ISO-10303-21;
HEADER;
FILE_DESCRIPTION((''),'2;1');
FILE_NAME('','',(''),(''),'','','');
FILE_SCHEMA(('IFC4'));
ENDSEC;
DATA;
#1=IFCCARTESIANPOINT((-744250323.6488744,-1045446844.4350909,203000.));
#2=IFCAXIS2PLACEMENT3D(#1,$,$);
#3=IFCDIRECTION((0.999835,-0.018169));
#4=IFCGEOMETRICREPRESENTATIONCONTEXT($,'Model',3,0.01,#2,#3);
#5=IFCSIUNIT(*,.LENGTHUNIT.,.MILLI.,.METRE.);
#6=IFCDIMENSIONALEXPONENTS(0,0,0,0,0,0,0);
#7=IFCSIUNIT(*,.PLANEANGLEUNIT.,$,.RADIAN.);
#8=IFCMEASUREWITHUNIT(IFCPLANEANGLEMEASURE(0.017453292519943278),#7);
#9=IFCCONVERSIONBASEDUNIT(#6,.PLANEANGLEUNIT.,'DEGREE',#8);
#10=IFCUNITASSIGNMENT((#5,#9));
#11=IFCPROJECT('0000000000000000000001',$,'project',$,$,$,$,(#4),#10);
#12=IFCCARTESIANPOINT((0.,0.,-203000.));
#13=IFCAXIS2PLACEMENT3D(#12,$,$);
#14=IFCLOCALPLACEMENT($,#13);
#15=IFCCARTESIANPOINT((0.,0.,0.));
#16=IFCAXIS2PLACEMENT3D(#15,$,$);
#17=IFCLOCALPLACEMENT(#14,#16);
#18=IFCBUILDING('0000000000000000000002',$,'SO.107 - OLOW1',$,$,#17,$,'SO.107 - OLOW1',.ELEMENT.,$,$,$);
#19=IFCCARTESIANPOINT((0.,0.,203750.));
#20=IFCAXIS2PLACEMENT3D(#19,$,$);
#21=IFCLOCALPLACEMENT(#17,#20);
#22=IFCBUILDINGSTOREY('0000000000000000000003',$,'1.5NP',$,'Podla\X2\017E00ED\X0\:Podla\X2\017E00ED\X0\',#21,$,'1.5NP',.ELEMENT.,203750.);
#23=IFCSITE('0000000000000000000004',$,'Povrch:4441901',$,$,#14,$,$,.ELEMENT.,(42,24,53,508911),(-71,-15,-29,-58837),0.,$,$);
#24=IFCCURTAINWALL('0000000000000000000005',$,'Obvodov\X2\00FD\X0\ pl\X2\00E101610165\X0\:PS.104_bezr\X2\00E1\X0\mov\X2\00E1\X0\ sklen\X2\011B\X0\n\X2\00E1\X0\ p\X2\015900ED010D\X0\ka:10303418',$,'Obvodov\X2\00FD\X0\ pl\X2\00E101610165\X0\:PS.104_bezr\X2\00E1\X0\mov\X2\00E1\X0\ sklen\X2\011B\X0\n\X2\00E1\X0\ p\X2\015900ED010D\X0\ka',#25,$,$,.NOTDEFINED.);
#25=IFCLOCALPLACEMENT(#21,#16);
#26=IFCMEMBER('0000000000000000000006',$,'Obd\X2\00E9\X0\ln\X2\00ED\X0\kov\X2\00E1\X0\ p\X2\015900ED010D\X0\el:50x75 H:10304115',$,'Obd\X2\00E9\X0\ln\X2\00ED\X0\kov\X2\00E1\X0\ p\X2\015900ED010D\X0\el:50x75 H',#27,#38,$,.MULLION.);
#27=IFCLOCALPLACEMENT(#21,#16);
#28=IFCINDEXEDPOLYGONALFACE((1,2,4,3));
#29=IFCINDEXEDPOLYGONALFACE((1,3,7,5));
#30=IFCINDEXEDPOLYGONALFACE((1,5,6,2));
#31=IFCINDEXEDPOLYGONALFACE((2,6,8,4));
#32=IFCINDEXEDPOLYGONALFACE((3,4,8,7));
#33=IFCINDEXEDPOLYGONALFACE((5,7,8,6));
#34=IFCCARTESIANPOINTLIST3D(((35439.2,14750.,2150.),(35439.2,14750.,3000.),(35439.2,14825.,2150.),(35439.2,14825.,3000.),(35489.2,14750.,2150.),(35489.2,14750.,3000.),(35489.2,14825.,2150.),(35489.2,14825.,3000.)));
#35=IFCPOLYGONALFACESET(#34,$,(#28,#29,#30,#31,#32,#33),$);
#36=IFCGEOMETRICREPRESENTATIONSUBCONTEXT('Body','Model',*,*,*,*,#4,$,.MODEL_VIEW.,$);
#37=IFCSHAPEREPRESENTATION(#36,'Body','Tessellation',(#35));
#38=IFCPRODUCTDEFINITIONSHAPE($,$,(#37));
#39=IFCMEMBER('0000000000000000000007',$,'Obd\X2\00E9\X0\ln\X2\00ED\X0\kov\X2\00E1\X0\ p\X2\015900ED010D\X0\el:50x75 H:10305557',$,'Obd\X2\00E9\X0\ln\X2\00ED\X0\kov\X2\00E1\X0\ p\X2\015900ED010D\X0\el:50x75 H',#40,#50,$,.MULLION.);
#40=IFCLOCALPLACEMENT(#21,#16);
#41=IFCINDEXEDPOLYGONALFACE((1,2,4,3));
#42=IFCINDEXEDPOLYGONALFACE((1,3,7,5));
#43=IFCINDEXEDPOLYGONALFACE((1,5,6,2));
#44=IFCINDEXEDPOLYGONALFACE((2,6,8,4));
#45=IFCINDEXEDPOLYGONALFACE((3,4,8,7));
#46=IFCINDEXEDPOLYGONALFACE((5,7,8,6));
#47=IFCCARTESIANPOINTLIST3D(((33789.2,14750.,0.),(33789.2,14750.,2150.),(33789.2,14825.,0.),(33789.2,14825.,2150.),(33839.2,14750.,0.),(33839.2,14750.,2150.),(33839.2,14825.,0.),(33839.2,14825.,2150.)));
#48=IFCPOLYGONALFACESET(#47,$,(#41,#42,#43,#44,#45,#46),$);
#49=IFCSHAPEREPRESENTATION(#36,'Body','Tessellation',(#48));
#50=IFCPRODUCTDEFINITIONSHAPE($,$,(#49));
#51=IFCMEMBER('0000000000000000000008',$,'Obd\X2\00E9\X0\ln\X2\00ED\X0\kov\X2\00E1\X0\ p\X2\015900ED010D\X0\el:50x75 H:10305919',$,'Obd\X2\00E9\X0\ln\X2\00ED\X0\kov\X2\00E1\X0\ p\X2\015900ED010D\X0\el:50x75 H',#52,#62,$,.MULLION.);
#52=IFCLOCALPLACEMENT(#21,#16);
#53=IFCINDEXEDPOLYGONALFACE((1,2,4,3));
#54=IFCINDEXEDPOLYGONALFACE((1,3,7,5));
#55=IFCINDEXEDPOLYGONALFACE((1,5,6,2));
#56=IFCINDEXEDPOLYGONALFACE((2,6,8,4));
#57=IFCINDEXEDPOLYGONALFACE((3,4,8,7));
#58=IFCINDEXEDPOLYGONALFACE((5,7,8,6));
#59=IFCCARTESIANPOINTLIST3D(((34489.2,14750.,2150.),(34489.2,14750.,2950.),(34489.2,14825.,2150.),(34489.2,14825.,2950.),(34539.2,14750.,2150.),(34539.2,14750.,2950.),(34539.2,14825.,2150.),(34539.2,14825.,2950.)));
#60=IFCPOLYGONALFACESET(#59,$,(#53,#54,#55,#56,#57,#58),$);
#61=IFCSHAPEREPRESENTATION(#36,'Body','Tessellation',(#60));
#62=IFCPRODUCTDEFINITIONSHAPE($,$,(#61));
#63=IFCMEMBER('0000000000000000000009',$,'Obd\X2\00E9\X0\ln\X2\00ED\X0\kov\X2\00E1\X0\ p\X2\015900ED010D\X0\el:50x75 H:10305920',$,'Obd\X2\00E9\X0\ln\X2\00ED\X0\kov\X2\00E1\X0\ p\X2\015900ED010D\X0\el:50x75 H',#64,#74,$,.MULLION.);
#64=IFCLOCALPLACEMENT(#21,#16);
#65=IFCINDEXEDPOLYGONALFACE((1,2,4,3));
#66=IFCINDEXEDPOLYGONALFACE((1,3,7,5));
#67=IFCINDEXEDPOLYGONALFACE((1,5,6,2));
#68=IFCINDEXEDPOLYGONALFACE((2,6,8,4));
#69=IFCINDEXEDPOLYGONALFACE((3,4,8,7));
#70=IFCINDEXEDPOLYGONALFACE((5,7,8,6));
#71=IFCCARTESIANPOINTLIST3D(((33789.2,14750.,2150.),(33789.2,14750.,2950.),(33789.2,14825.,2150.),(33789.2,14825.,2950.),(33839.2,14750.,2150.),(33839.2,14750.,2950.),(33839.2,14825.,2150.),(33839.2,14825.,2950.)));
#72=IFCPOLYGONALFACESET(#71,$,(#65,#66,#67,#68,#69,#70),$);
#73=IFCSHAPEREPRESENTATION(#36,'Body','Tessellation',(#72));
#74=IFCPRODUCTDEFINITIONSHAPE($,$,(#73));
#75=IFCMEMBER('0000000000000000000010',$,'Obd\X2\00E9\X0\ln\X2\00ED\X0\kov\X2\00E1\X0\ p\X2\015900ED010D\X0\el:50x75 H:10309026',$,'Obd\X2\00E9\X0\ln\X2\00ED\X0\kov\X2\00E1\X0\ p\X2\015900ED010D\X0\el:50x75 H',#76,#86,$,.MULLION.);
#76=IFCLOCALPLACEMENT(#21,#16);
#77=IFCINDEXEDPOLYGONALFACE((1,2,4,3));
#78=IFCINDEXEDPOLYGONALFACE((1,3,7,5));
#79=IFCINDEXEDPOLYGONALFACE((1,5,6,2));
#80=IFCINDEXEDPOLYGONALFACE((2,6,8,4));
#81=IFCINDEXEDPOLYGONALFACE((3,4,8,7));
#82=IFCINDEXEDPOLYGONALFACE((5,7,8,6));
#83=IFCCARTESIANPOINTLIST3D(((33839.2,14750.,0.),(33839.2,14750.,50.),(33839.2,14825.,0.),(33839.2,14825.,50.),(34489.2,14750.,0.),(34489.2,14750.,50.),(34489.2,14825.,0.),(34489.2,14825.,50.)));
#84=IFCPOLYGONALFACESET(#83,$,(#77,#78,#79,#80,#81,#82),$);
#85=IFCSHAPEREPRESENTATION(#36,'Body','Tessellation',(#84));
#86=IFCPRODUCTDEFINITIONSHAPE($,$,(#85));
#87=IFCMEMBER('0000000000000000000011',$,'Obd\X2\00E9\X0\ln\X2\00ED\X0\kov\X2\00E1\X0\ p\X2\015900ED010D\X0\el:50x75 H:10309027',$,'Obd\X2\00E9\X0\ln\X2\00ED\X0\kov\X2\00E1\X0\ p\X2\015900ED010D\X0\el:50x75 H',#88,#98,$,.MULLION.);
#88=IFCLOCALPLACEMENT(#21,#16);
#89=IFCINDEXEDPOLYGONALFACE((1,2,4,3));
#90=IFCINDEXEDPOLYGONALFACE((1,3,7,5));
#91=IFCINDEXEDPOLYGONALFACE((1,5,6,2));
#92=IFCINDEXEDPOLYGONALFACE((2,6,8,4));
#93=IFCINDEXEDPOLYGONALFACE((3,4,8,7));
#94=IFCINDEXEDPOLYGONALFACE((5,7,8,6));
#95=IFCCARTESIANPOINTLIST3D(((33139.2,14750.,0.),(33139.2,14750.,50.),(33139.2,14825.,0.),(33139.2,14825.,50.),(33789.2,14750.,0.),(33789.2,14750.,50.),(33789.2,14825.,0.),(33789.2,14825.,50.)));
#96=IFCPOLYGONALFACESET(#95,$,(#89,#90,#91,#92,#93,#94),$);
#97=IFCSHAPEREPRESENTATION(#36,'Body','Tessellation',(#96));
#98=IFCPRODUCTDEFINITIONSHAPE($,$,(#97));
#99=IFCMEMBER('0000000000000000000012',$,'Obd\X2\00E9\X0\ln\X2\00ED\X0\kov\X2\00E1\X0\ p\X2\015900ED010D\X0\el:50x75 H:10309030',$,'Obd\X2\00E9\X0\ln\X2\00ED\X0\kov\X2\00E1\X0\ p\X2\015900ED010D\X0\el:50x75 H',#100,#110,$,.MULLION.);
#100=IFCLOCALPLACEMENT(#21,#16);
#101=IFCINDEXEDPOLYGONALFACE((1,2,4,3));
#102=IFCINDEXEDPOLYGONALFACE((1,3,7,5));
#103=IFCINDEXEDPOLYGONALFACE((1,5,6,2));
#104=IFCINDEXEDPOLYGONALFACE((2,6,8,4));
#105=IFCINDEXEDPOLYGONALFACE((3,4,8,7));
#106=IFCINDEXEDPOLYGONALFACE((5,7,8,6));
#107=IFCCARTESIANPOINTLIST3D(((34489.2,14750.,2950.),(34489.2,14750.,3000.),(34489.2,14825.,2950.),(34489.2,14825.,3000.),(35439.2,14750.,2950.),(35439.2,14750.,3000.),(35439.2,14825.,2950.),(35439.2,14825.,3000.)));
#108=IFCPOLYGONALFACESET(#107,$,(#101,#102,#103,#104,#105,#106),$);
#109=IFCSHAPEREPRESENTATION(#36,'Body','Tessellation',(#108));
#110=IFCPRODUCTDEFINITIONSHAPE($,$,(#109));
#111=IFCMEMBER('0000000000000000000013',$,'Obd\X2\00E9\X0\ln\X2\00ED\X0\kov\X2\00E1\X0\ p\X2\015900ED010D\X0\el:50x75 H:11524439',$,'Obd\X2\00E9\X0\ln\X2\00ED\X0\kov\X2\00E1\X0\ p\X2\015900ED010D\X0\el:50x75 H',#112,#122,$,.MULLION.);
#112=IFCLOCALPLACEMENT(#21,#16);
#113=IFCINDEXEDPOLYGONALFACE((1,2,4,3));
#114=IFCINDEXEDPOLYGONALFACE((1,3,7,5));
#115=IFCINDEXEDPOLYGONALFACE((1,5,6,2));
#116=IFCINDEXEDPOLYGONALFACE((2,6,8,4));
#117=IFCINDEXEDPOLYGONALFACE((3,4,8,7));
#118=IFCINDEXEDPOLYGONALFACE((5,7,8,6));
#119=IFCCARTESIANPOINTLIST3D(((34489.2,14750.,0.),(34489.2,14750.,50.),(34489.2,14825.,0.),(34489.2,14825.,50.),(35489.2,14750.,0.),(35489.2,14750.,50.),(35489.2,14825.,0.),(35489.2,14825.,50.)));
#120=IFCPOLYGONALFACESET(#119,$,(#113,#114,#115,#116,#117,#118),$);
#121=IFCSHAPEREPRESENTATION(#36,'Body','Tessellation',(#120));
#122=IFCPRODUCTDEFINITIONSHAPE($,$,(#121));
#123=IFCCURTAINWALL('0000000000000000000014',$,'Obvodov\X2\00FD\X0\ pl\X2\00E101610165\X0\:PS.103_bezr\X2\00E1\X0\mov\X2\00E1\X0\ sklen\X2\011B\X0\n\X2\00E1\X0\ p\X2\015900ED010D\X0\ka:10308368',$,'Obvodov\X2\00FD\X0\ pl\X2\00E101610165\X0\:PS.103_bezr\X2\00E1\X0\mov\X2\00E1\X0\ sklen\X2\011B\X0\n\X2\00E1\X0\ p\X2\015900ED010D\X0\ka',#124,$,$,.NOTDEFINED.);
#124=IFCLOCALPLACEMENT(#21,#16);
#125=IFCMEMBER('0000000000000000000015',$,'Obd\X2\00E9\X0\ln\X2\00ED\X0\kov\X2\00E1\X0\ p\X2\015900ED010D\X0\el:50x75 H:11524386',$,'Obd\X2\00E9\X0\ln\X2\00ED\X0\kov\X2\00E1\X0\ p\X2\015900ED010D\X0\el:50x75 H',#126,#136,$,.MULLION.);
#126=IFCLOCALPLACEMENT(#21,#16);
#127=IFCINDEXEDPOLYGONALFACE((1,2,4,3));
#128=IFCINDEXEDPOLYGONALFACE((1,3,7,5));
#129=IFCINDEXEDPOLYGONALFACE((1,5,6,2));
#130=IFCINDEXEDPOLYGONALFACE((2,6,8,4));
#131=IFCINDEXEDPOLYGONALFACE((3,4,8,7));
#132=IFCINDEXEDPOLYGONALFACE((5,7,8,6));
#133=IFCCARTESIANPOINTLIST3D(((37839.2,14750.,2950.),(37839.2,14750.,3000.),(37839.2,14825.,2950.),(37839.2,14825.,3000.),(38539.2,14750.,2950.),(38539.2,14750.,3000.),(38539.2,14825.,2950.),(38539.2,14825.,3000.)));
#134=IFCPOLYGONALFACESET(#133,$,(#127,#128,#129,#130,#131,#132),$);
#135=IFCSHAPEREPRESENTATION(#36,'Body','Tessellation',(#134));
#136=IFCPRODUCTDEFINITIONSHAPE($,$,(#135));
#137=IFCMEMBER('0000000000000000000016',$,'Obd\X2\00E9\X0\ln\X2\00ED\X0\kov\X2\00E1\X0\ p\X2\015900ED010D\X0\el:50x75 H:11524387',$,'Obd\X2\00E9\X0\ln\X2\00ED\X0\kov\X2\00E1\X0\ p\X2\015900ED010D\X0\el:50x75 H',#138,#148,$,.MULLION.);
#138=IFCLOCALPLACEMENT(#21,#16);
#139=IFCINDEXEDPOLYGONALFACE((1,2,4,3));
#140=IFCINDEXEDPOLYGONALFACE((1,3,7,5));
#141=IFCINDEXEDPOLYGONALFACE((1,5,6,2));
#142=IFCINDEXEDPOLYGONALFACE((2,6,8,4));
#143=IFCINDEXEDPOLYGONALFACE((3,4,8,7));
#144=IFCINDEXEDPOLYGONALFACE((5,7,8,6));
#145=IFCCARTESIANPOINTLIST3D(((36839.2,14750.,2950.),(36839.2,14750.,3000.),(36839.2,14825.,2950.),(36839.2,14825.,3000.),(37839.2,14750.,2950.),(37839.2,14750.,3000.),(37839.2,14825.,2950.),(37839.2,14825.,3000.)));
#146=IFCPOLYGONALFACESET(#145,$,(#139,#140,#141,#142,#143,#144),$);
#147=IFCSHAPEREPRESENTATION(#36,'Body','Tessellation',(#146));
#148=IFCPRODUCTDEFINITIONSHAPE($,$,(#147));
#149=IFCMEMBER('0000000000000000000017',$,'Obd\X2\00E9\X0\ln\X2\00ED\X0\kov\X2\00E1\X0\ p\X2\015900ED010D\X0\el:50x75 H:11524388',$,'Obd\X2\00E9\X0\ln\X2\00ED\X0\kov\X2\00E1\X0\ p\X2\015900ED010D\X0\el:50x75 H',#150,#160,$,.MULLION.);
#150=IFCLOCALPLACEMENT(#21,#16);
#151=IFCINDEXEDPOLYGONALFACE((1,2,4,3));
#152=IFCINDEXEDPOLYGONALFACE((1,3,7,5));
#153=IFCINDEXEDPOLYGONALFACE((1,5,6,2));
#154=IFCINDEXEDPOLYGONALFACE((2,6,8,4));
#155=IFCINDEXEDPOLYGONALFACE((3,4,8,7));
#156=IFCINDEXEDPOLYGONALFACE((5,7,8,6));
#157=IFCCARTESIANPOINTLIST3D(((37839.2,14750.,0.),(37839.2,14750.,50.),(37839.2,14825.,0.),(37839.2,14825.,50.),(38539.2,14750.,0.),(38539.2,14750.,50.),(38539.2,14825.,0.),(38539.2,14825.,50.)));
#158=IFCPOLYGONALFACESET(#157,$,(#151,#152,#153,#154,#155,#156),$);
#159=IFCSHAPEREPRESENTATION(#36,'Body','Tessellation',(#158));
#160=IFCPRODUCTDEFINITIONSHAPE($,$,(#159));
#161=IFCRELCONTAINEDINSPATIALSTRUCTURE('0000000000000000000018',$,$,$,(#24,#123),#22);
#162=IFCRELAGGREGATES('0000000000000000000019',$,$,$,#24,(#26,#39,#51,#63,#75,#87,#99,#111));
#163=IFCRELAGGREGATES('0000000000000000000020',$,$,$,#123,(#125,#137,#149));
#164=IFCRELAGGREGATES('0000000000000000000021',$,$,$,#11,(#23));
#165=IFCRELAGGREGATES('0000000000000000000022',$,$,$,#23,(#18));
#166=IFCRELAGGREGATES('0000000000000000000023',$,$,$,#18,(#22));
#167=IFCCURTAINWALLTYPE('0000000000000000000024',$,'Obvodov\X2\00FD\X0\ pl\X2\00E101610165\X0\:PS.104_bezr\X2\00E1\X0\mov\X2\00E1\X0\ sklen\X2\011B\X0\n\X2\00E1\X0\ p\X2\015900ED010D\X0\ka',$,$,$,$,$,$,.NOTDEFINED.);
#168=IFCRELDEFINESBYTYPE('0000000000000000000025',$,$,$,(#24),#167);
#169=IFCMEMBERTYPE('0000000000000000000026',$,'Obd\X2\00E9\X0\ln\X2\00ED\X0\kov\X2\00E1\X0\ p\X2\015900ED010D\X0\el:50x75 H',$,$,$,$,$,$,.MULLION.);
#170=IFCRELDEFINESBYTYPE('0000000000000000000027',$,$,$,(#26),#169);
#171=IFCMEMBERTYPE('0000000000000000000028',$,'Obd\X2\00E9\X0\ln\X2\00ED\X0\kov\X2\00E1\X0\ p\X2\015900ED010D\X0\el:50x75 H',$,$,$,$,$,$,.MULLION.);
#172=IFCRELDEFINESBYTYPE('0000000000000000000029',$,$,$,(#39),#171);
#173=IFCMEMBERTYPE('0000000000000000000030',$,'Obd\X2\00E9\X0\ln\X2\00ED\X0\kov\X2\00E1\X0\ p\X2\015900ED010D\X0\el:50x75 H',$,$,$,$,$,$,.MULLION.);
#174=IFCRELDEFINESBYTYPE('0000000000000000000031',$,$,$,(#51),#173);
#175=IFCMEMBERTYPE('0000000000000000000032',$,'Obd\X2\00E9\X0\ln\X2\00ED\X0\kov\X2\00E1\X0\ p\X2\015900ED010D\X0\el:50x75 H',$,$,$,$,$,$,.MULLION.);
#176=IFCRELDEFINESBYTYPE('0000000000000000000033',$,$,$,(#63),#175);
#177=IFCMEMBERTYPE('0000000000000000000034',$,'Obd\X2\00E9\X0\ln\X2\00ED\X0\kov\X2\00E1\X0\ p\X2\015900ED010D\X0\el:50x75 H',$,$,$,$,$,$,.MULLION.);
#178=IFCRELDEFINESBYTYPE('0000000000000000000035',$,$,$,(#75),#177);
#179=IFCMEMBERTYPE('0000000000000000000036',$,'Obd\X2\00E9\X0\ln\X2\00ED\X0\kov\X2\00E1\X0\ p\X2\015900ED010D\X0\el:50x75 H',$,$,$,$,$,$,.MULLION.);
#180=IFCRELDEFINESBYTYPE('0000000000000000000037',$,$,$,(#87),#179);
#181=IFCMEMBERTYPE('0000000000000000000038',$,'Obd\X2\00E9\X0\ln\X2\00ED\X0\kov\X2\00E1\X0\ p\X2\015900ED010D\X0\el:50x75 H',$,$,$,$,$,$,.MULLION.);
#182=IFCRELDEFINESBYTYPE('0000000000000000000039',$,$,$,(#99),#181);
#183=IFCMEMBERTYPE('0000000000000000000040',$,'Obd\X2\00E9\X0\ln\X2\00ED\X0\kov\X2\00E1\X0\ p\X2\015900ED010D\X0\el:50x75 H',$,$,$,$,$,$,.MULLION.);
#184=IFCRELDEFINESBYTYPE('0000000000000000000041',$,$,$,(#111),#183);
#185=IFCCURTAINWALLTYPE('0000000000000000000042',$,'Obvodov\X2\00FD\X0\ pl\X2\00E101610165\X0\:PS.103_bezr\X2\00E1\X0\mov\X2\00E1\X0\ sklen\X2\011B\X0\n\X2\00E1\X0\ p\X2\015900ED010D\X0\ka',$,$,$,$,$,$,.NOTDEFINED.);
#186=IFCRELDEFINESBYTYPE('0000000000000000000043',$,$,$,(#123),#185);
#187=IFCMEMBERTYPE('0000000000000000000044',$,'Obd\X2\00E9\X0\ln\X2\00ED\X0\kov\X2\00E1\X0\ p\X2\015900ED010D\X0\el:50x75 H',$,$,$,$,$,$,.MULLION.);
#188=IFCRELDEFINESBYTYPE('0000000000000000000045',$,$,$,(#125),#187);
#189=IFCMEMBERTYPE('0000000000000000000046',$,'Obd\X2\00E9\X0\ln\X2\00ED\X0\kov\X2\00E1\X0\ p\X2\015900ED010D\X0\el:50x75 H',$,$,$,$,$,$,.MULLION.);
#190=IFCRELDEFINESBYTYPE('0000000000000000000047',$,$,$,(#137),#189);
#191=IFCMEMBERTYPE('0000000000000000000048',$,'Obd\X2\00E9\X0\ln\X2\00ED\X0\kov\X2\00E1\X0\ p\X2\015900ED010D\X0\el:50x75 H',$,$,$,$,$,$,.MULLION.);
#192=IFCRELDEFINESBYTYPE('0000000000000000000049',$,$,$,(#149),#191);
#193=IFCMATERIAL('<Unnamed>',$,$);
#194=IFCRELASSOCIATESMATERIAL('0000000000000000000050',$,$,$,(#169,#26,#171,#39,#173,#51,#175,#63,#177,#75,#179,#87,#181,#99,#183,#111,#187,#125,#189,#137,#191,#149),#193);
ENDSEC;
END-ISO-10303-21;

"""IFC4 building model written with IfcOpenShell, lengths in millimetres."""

from ifc_helpers import new_model, entity, si_unit, converted_unit, direction, frame, origin, place, context, subcontext, project, spatial, indexed_curve, outline, extrude, source, transform, mapped, material, type_object, type_shapes, element, aggregate, save


model = new_model("IFC4")

# Units and contexts
model_context = context("Model", 3, precision=0.01, world=frame((-744250323.6488744, -1045446844.4350909, 203000.0)), true_north=direction((0.999835, -0.018169)))
body_context = subcontext(model_context, "Body", "Model", "MODEL_VIEW")
ifc_project = project(units=[si_unit("LENGTHUNIT", "METRE", prefix="MILLI"), converted_unit("PLANEANGLEUNIT", "DEGREE", entity("IfcPlaneAngleMeasure", 0.017453292519943278), si_unit("PLANEANGLEUNIT", "RADIAN"), dimensions=[0, 0, 0, 0, 0, 0, 0])], contexts=[model_context])

# Site, building, storey
site_placement = place(None, frame((0.0, 0.0, -203000.0)))
site = spatial("IfcSite", under=ifc_project, at=site_placement, Name="Povrch:4441901", CompositionType="ELEMENT", RefLatitude=(42, 24, 53, 508911), RefLongitude=(-71, -15, -29, -58837), RefElevation=0.0)
building_placement = place(site_placement, origin())
building = spatial("IfcBuilding", under=site, at=building_placement, Name="SO.107 - OLOW1", LongName="SO.107 - OLOW1", CompositionType="ELEMENT")
storey_placement = place(building_placement, frame((0.0, 0.0, 203750.0)))
storey = spatial("IfcBuildingStorey", under=building, at=storey_placement, Name="1.5NP", ObjectType="Podlaží:Podlaží", LongName="1.5NP", CompositionType="ELEMENT", Elevation=203750.0)

# Curtain walls, members
curtain_wall_type_1 = type_object("IfcCurtainWallType", Name="Obvodový plášť:PS.104_bezrámová skleněná příčka", PredefinedType="NOTDEFINED")
curtain_wall_1_placement = place(storey_placement, frame((0.0, 0.0, -203750.0)))
curtain_wall_1 = element("IfcCurtainWall", 1, at=curtain_wall_1_placement, inside=storey, type_object=curtain_wall_type_1, Name="Obvodový plášť:PS.104_bezrámová skleněná příčka:10303418", ObjectType="Obvodový plášť:PS.104_bezrámová skleněná příčka", PredefinedType="NOTDEFINED")
ifc_material_1 = material(Name="<Unnamed>")
member_type_1 = type_object("IfcMemberType", Name="Obdélníková příčel:50x75 H", PredefinedType="MULLION", material=ifc_material_1)
shared_shape_1 = source(origin(), body_context, "Body", "SweptSolid", [
    extrude(outline(indexed_curve([(-25.0, -37.5), (25.0, -37.5), (25.0, 37.5), (-25.0, 37.5), (-25.0, -37.5)], self_intersect=False)), frame((-25.0, 37.5, -850.0), z_axis=(0.0, 0.0, 1.0), x_axis=(-1.0, 0.0, 0.0)), (0.0, 0.0, 1.0), 850.0),
])
type_shapes(member_type_1, [shared_shape_1])
member_1_placement = place(curtain_wall_1_placement, frame((35489.2, 14750.0, 206750.0)))
member_1 = element("IfcMember", 2, at=member_1_placement, type_object=member_type_1, material=ifc_material_1, Name="Obdélníková příčel:50x75 H:10304115", ObjectType="Obdélníková příčel:50x75 H", PredefinedType="MULLION", context=body_context, shape_type="MappedRepresentation", body=[
    mapped(shared_shape_1, transform((0.0, 0.0, 0.0), scale=1.0)),
])
member_type_2 = type_object("IfcMemberType", Name="Obdélníková příčel:50x75 H", PredefinedType="MULLION", material=ifc_material_1)
shared_shape_2 = source(origin(), body_context, "Body", "SweptSolid", [
    extrude(outline(indexed_curve([(-25.0, -37.5), (25.0, -37.5), (25.0, 37.5), (-25.0, 37.5), (-25.0, -37.5)], self_intersect=False)), frame((-25.0, 37.5, -2150.0), z_axis=(0.0, 0.0, 1.0), x_axis=(-1.0, 0.0, 0.0)), (0.0, 0.0, 1.0), 2150.0),
])
type_shapes(member_type_2, [shared_shape_2])
member_2_placement = place(curtain_wall_1_placement, frame((33789.2, 14750.0, 203750.0), z_axis=(0.0, 0.0, -1.0), x_axis=(-1.0, 0.0, 0.0)))
member_2 = element("IfcMember", 3, at=member_2_placement, type_object=member_type_2, material=ifc_material_1, Name="Obdélníková příčel:50x75 H:10305557", ObjectType="Obdélníková příčel:50x75 H", PredefinedType="MULLION", context=body_context, shape_type="MappedRepresentation", body=[
    mapped(shared_shape_2, transform((0.0, 0.0, 0.0), scale=1.0)),
])
member_type_3 = type_object("IfcMemberType", Name="Obdélníková příčel:50x75 H", PredefinedType="MULLION", material=ifc_material_1)
shared_shape_3 = source(origin(), body_context, "Body", "SweptSolid", [
    extrude(outline(indexed_curve([(-25.0, -37.5), (25.0, -37.5), (25.0, 37.5), (-25.0, 37.5), (-25.0, -37.5)], self_intersect=False)), frame((-25.0, 37.5, -800.0), z_axis=(0.0, 0.0, 1.0), x_axis=(-1.0, 0.0, 0.0)), (0.0, 0.0, 1.0), 800.0),
])
type_shapes(member_type_3, [shared_shape_3])
member_3_placement = place(curtain_wall_1_placement, frame((34489.2, 14750.0, 205900.0), z_axis=(0.0, 0.0, -1.0), x_axis=(-1.0, 0.0, 0.0)))
member_3 = element("IfcMember", 4, at=member_3_placement, type_object=member_type_3, material=ifc_material_1, Name="Obdélníková příčel:50x75 H:10305919", ObjectType="Obdélníková příčel:50x75 H", PredefinedType="MULLION", context=body_context, shape_type="MappedRepresentation", body=[
    mapped(shared_shape_3, transform((0.0, 0.0, 0.0), scale=1.0)),
])
member_type_4 = type_object("IfcMemberType", Name="Obdélníková příčel:50x75 H", PredefinedType="MULLION", material=ifc_material_1)
shared_shape_4 = source(origin(), body_context, "Body", "SweptSolid", [
    extrude(outline(indexed_curve([(-25.0, -37.5), (25.0, -37.5), (25.0, 37.5), (-25.0, 37.5), (-25.0, -37.5)], self_intersect=False)), frame((-25.0, 37.5, -800.0), z_axis=(0.0, 0.0, 1.0), x_axis=(-1.0, 0.0, 0.0)), (0.0, 0.0, 1.0), 800.0),
])
type_shapes(member_type_4, [shared_shape_4])
member_4_placement = place(curtain_wall_1_placement, frame((33789.2, 14750.0, 205900.0), z_axis=(0.0, 0.0, -1.0), x_axis=(-1.0, 0.0, 0.0)))
member_4 = element("IfcMember", 5, at=member_4_placement, type_object=member_type_4, material=ifc_material_1, Name="Obdélníková příčel:50x75 H:10305920", ObjectType="Obdélníková příčel:50x75 H", PredefinedType="MULLION", context=body_context, shape_type="MappedRepresentation", body=[
    mapped(shared_shape_4, transform((0.0, 0.0, 0.0), scale=1.0)),
])
member_type_5 = type_object("IfcMemberType", Name="Obdélníková příčel:50x75 H", PredefinedType="MULLION", material=ifc_material_1)
shared_shape_5 = source(origin(), body_context, "Body", "SweptSolid", [
    extrude(outline(indexed_curve([(-25.0, -37.5), (25.0, -37.5), (25.0, 37.5), (-25.0, 37.5), (-25.0, -37.5)], self_intersect=False)), frame((-25.0, 37.5, -650.0), z_axis=(0.0, 0.0, 1.0), x_axis=(-1.0, 0.0, 0.0)), (0.0, 0.0, 1.0), 650.0),
])
type_shapes(member_type_5, [shared_shape_5])
member_5_placement = place(curtain_wall_1_placement, frame((34489.2, 14750.0, 203750.0), z_axis=(1.0, 0.0, 0.0), x_axis=(0.0, 0.0, -1.0)))
member_5 = element("IfcMember", 6, at=member_5_placement, type_object=member_type_5, material=ifc_material_1, Name="Obdélníková příčel:50x75 H:10309026", ObjectType="Obdélníková příčel:50x75 H", PredefinedType="MULLION", context=body_context, shape_type="MappedRepresentation", body=[
    mapped(shared_shape_5, transform((0.0, 0.0, 0.0), scale=1.0)),
])
member_type_6 = type_object("IfcMemberType", Name="Obdélníková příčel:50x75 H", PredefinedType="MULLION", material=ifc_material_1)
shared_shape_6 = source(origin(), body_context, "Body", "SweptSolid", [
    extrude(outline(indexed_curve([(-25.0, -37.5), (25.0, -37.5), (25.0, 37.5), (-25.0, 37.5), (-25.0, -37.5)], self_intersect=False)), frame((-25.0, 37.5, -650.0), z_axis=(0.0, 0.0, 1.0), x_axis=(-1.0, 0.0, 0.0)), (0.0, 0.0, 1.0), 650.0),
])
type_shapes(member_type_6, [shared_shape_6])
member_6_placement = place(curtain_wall_1_placement, frame((33789.2, 14750.0, 203750.0), z_axis=(1.0, 0.0, 0.0), x_axis=(0.0, 0.0, -1.0)))
member_6 = element("IfcMember", 7, at=member_6_placement, type_object=member_type_6, material=ifc_material_1, Name="Obdélníková příčel:50x75 H:10309027", ObjectType="Obdélníková příčel:50x75 H", PredefinedType="MULLION", context=body_context, shape_type="MappedRepresentation", body=[
    mapped(shared_shape_6, transform((0.0, 0.0, 0.0), scale=1.0)),
])
member_type_7 = type_object("IfcMemberType", Name="Obdélníková příčel:50x75 H", PredefinedType="MULLION", material=ifc_material_1)
shared_shape_7 = source(origin(), body_context, "Body", "SweptSolid", [
    extrude(outline(indexed_curve([(-25.0, -37.5), (25.0, -37.5), (25.0, 37.5), (-25.0, 37.5), (-25.0, -37.5)], self_intersect=False)), frame((-25.0, 37.5, -950.0), z_axis=(0.0, 0.0, 1.0), x_axis=(-1.0, 0.0, 0.0)), (0.0, 0.0, 1.0), 950.0),
])
type_shapes(member_type_7, [shared_shape_7])
member_7_placement = place(curtain_wall_1_placement, frame((34489.2, 14750.0, 206750.0), z_axis=(-1.0, 0.0, 0.0), x_axis=(0.0, 0.0, 1.0)))
member_7 = element("IfcMember", 8, at=member_7_placement, type_object=member_type_7, material=ifc_material_1, Name="Obdélníková příčel:50x75 H:10309030", ObjectType="Obdélníková příčel:50x75 H", PredefinedType="MULLION", context=body_context, shape_type="MappedRepresentation", body=[
    mapped(shared_shape_7, transform((0.0, 0.0, 0.0), scale=1.0)),
])
member_type_8 = type_object("IfcMemberType", Name="Obdélníková příčel:50x75 H", PredefinedType="MULLION", material=ifc_material_1)
shared_shape_8 = source(origin(), body_context, "Body", "SweptSolid", [
    extrude(outline(indexed_curve([(-25.0, -37.5), (25.0, -37.5), (25.0, 37.5), (-25.0, 37.5), (-25.0, -37.5)], self_intersect=False)), frame((-25.0, 37.5, -1000.0), z_axis=(0.0, 0.0, 1.0), x_axis=(-1.0, 0.0, 0.0)), (0.0, 0.0, 1.0), 1000.0),
])
type_shapes(member_type_8, [shared_shape_8])
member_8_placement = place(curtain_wall_1_placement, frame((35489.2, 14750.0, 203750.0), z_axis=(1.0, 0.0, 0.0), x_axis=(0.0, 0.0, -1.0)))
member_8 = element("IfcMember", 9, at=member_8_placement, type_object=member_type_8, material=ifc_material_1, Name="Obdélníková příčel:50x75 H:11524439", ObjectType="Obdélníková příčel:50x75 H", PredefinedType="MULLION", context=body_context, shape_type="MappedRepresentation", body=[
    mapped(shared_shape_8, transform((0.0, 0.0, 0.0), scale=1.0)),
])
curtain_wall_type_2 = type_object("IfcCurtainWallType", Name="Obvodový plášť:PS.103_bezrámová skleněná příčka", PredefinedType="NOTDEFINED")
curtain_wall_2_placement = place(storey_placement, frame((0.0, 0.0, -203750.0)))
curtain_wall_2 = element("IfcCurtainWall", 10, at=curtain_wall_2_placement, inside=storey, type_object=curtain_wall_type_2, Name="Obvodový plášť:PS.103_bezrámová skleněná příčka:10308368", ObjectType="Obvodový plášť:PS.103_bezrámová skleněná příčka", PredefinedType="NOTDEFINED")
member_type_9 = type_object("IfcMemberType", Name="Obdélníková příčel:50x75 H", PredefinedType="MULLION", material=ifc_material_1)
shared_shape_9 = source(origin(), body_context, "Body", "SweptSolid", [
    extrude(outline(indexed_curve([(-25.0, -37.5), (25.0, -37.5), (25.0, 37.5), (-25.0, 37.5), (-25.0, -37.5)], self_intersect=False)), frame((-25.0, -37.5, -700.0), z_axis=(0.0, 0.0, 1.0), x_axis=(-1.0, 0.0, 0.0)), (0.0, 0.0, 1.0), 700.0),
])
type_shapes(member_type_9, [shared_shape_9])
member_9_placement = place(curtain_wall_2_placement, frame((38539.2, 14750.0, 206750.0), z_axis=(1.0, 0.0, 0.0), x_axis=(0.0, 0.0, 1.0)))
member_9 = element("IfcMember", 11, at=member_9_placement, type_object=member_type_9, material=ifc_material_1, Name="Obdélníková příčel:50x75 H:11524386", ObjectType="Obdélníková příčel:50x75 H", PredefinedType="MULLION", context=body_context, shape_type="MappedRepresentation", body=[
    mapped(shared_shape_9, transform((0.0, 0.0, 0.0), scale=1.0)),
])
member_type_10 = type_object("IfcMemberType", Name="Obdélníková příčel:50x75 H", PredefinedType="MULLION", material=ifc_material_1)
shared_shape_10 = source(origin(), body_context, "Body", "SweptSolid", [
    extrude(outline(indexed_curve([(-25.0, -37.5), (25.0, -37.5), (25.0, 37.5), (-25.0, 37.5), (-25.0, -37.5)], self_intersect=False)), frame((-25.0, -37.5, -1000.0), z_axis=(0.0, 0.0, 1.0), x_axis=(-1.0, 0.0, 0.0)), (0.0, 0.0, 1.0), 1000.0),
])
type_shapes(member_type_10, [shared_shape_10])
member_10_placement = place(curtain_wall_2_placement, frame((37839.2, 14750.0, 206750.0), z_axis=(1.0, 0.0, 0.0), x_axis=(0.0, 0.0, 1.0)))
member_10 = element("IfcMember", 12, at=member_10_placement, type_object=member_type_10, material=ifc_material_1, Name="Obdélníková příčel:50x75 H:11524387", ObjectType="Obdélníková příčel:50x75 H", PredefinedType="MULLION", context=body_context, shape_type="MappedRepresentation", body=[
    mapped(shared_shape_10, transform((0.0, 0.0, 0.0), scale=1.0)),
])
member_type_11 = type_object("IfcMemberType", Name="Obdélníková příčel:50x75 H", PredefinedType="MULLION", material=ifc_material_1)
shared_shape_11 = source(origin(), body_context, "Body", "SweptSolid", [
    extrude(outline(indexed_curve([(-25.0, -37.5), (25.0, -37.5), (25.0, 37.5), (-25.0, 37.5), (-25.0, -37.5)], self_intersect=False)), frame((-25.0, -37.5, -700.0), z_axis=(0.0, 0.0, 1.0), x_axis=(-1.0, 0.0, 0.0)), (0.0, 0.0, 1.0), 700.0),
])
type_shapes(member_type_11, [shared_shape_11])
member_11_placement = place(curtain_wall_2_placement, frame((37839.2, 14750.0, 203750.0), z_axis=(-1.0, 0.0, 0.0), x_axis=(0.0, 0.0, -1.0)))
member_11 = element("IfcMember", 13, at=member_11_placement, type_object=member_type_11, material=ifc_material_1, Name="Obdélníková příčel:50x75 H:11524388", ObjectType="Obdélníková příčel:50x75 H", PredefinedType="MULLION", context=body_context, shape_type="MappedRepresentation", body=[
    mapped(shared_shape_11, transform((0.0, 0.0, 0.0), scale=1.0)),
])

aggregate(curtain_wall_1, [member_1, member_2, member_3, member_4, member_5, member_6, member_7, member_8])
aggregate(curtain_wall_2, [member_9, member_10, member_11])

save(model, "model.ifc")
